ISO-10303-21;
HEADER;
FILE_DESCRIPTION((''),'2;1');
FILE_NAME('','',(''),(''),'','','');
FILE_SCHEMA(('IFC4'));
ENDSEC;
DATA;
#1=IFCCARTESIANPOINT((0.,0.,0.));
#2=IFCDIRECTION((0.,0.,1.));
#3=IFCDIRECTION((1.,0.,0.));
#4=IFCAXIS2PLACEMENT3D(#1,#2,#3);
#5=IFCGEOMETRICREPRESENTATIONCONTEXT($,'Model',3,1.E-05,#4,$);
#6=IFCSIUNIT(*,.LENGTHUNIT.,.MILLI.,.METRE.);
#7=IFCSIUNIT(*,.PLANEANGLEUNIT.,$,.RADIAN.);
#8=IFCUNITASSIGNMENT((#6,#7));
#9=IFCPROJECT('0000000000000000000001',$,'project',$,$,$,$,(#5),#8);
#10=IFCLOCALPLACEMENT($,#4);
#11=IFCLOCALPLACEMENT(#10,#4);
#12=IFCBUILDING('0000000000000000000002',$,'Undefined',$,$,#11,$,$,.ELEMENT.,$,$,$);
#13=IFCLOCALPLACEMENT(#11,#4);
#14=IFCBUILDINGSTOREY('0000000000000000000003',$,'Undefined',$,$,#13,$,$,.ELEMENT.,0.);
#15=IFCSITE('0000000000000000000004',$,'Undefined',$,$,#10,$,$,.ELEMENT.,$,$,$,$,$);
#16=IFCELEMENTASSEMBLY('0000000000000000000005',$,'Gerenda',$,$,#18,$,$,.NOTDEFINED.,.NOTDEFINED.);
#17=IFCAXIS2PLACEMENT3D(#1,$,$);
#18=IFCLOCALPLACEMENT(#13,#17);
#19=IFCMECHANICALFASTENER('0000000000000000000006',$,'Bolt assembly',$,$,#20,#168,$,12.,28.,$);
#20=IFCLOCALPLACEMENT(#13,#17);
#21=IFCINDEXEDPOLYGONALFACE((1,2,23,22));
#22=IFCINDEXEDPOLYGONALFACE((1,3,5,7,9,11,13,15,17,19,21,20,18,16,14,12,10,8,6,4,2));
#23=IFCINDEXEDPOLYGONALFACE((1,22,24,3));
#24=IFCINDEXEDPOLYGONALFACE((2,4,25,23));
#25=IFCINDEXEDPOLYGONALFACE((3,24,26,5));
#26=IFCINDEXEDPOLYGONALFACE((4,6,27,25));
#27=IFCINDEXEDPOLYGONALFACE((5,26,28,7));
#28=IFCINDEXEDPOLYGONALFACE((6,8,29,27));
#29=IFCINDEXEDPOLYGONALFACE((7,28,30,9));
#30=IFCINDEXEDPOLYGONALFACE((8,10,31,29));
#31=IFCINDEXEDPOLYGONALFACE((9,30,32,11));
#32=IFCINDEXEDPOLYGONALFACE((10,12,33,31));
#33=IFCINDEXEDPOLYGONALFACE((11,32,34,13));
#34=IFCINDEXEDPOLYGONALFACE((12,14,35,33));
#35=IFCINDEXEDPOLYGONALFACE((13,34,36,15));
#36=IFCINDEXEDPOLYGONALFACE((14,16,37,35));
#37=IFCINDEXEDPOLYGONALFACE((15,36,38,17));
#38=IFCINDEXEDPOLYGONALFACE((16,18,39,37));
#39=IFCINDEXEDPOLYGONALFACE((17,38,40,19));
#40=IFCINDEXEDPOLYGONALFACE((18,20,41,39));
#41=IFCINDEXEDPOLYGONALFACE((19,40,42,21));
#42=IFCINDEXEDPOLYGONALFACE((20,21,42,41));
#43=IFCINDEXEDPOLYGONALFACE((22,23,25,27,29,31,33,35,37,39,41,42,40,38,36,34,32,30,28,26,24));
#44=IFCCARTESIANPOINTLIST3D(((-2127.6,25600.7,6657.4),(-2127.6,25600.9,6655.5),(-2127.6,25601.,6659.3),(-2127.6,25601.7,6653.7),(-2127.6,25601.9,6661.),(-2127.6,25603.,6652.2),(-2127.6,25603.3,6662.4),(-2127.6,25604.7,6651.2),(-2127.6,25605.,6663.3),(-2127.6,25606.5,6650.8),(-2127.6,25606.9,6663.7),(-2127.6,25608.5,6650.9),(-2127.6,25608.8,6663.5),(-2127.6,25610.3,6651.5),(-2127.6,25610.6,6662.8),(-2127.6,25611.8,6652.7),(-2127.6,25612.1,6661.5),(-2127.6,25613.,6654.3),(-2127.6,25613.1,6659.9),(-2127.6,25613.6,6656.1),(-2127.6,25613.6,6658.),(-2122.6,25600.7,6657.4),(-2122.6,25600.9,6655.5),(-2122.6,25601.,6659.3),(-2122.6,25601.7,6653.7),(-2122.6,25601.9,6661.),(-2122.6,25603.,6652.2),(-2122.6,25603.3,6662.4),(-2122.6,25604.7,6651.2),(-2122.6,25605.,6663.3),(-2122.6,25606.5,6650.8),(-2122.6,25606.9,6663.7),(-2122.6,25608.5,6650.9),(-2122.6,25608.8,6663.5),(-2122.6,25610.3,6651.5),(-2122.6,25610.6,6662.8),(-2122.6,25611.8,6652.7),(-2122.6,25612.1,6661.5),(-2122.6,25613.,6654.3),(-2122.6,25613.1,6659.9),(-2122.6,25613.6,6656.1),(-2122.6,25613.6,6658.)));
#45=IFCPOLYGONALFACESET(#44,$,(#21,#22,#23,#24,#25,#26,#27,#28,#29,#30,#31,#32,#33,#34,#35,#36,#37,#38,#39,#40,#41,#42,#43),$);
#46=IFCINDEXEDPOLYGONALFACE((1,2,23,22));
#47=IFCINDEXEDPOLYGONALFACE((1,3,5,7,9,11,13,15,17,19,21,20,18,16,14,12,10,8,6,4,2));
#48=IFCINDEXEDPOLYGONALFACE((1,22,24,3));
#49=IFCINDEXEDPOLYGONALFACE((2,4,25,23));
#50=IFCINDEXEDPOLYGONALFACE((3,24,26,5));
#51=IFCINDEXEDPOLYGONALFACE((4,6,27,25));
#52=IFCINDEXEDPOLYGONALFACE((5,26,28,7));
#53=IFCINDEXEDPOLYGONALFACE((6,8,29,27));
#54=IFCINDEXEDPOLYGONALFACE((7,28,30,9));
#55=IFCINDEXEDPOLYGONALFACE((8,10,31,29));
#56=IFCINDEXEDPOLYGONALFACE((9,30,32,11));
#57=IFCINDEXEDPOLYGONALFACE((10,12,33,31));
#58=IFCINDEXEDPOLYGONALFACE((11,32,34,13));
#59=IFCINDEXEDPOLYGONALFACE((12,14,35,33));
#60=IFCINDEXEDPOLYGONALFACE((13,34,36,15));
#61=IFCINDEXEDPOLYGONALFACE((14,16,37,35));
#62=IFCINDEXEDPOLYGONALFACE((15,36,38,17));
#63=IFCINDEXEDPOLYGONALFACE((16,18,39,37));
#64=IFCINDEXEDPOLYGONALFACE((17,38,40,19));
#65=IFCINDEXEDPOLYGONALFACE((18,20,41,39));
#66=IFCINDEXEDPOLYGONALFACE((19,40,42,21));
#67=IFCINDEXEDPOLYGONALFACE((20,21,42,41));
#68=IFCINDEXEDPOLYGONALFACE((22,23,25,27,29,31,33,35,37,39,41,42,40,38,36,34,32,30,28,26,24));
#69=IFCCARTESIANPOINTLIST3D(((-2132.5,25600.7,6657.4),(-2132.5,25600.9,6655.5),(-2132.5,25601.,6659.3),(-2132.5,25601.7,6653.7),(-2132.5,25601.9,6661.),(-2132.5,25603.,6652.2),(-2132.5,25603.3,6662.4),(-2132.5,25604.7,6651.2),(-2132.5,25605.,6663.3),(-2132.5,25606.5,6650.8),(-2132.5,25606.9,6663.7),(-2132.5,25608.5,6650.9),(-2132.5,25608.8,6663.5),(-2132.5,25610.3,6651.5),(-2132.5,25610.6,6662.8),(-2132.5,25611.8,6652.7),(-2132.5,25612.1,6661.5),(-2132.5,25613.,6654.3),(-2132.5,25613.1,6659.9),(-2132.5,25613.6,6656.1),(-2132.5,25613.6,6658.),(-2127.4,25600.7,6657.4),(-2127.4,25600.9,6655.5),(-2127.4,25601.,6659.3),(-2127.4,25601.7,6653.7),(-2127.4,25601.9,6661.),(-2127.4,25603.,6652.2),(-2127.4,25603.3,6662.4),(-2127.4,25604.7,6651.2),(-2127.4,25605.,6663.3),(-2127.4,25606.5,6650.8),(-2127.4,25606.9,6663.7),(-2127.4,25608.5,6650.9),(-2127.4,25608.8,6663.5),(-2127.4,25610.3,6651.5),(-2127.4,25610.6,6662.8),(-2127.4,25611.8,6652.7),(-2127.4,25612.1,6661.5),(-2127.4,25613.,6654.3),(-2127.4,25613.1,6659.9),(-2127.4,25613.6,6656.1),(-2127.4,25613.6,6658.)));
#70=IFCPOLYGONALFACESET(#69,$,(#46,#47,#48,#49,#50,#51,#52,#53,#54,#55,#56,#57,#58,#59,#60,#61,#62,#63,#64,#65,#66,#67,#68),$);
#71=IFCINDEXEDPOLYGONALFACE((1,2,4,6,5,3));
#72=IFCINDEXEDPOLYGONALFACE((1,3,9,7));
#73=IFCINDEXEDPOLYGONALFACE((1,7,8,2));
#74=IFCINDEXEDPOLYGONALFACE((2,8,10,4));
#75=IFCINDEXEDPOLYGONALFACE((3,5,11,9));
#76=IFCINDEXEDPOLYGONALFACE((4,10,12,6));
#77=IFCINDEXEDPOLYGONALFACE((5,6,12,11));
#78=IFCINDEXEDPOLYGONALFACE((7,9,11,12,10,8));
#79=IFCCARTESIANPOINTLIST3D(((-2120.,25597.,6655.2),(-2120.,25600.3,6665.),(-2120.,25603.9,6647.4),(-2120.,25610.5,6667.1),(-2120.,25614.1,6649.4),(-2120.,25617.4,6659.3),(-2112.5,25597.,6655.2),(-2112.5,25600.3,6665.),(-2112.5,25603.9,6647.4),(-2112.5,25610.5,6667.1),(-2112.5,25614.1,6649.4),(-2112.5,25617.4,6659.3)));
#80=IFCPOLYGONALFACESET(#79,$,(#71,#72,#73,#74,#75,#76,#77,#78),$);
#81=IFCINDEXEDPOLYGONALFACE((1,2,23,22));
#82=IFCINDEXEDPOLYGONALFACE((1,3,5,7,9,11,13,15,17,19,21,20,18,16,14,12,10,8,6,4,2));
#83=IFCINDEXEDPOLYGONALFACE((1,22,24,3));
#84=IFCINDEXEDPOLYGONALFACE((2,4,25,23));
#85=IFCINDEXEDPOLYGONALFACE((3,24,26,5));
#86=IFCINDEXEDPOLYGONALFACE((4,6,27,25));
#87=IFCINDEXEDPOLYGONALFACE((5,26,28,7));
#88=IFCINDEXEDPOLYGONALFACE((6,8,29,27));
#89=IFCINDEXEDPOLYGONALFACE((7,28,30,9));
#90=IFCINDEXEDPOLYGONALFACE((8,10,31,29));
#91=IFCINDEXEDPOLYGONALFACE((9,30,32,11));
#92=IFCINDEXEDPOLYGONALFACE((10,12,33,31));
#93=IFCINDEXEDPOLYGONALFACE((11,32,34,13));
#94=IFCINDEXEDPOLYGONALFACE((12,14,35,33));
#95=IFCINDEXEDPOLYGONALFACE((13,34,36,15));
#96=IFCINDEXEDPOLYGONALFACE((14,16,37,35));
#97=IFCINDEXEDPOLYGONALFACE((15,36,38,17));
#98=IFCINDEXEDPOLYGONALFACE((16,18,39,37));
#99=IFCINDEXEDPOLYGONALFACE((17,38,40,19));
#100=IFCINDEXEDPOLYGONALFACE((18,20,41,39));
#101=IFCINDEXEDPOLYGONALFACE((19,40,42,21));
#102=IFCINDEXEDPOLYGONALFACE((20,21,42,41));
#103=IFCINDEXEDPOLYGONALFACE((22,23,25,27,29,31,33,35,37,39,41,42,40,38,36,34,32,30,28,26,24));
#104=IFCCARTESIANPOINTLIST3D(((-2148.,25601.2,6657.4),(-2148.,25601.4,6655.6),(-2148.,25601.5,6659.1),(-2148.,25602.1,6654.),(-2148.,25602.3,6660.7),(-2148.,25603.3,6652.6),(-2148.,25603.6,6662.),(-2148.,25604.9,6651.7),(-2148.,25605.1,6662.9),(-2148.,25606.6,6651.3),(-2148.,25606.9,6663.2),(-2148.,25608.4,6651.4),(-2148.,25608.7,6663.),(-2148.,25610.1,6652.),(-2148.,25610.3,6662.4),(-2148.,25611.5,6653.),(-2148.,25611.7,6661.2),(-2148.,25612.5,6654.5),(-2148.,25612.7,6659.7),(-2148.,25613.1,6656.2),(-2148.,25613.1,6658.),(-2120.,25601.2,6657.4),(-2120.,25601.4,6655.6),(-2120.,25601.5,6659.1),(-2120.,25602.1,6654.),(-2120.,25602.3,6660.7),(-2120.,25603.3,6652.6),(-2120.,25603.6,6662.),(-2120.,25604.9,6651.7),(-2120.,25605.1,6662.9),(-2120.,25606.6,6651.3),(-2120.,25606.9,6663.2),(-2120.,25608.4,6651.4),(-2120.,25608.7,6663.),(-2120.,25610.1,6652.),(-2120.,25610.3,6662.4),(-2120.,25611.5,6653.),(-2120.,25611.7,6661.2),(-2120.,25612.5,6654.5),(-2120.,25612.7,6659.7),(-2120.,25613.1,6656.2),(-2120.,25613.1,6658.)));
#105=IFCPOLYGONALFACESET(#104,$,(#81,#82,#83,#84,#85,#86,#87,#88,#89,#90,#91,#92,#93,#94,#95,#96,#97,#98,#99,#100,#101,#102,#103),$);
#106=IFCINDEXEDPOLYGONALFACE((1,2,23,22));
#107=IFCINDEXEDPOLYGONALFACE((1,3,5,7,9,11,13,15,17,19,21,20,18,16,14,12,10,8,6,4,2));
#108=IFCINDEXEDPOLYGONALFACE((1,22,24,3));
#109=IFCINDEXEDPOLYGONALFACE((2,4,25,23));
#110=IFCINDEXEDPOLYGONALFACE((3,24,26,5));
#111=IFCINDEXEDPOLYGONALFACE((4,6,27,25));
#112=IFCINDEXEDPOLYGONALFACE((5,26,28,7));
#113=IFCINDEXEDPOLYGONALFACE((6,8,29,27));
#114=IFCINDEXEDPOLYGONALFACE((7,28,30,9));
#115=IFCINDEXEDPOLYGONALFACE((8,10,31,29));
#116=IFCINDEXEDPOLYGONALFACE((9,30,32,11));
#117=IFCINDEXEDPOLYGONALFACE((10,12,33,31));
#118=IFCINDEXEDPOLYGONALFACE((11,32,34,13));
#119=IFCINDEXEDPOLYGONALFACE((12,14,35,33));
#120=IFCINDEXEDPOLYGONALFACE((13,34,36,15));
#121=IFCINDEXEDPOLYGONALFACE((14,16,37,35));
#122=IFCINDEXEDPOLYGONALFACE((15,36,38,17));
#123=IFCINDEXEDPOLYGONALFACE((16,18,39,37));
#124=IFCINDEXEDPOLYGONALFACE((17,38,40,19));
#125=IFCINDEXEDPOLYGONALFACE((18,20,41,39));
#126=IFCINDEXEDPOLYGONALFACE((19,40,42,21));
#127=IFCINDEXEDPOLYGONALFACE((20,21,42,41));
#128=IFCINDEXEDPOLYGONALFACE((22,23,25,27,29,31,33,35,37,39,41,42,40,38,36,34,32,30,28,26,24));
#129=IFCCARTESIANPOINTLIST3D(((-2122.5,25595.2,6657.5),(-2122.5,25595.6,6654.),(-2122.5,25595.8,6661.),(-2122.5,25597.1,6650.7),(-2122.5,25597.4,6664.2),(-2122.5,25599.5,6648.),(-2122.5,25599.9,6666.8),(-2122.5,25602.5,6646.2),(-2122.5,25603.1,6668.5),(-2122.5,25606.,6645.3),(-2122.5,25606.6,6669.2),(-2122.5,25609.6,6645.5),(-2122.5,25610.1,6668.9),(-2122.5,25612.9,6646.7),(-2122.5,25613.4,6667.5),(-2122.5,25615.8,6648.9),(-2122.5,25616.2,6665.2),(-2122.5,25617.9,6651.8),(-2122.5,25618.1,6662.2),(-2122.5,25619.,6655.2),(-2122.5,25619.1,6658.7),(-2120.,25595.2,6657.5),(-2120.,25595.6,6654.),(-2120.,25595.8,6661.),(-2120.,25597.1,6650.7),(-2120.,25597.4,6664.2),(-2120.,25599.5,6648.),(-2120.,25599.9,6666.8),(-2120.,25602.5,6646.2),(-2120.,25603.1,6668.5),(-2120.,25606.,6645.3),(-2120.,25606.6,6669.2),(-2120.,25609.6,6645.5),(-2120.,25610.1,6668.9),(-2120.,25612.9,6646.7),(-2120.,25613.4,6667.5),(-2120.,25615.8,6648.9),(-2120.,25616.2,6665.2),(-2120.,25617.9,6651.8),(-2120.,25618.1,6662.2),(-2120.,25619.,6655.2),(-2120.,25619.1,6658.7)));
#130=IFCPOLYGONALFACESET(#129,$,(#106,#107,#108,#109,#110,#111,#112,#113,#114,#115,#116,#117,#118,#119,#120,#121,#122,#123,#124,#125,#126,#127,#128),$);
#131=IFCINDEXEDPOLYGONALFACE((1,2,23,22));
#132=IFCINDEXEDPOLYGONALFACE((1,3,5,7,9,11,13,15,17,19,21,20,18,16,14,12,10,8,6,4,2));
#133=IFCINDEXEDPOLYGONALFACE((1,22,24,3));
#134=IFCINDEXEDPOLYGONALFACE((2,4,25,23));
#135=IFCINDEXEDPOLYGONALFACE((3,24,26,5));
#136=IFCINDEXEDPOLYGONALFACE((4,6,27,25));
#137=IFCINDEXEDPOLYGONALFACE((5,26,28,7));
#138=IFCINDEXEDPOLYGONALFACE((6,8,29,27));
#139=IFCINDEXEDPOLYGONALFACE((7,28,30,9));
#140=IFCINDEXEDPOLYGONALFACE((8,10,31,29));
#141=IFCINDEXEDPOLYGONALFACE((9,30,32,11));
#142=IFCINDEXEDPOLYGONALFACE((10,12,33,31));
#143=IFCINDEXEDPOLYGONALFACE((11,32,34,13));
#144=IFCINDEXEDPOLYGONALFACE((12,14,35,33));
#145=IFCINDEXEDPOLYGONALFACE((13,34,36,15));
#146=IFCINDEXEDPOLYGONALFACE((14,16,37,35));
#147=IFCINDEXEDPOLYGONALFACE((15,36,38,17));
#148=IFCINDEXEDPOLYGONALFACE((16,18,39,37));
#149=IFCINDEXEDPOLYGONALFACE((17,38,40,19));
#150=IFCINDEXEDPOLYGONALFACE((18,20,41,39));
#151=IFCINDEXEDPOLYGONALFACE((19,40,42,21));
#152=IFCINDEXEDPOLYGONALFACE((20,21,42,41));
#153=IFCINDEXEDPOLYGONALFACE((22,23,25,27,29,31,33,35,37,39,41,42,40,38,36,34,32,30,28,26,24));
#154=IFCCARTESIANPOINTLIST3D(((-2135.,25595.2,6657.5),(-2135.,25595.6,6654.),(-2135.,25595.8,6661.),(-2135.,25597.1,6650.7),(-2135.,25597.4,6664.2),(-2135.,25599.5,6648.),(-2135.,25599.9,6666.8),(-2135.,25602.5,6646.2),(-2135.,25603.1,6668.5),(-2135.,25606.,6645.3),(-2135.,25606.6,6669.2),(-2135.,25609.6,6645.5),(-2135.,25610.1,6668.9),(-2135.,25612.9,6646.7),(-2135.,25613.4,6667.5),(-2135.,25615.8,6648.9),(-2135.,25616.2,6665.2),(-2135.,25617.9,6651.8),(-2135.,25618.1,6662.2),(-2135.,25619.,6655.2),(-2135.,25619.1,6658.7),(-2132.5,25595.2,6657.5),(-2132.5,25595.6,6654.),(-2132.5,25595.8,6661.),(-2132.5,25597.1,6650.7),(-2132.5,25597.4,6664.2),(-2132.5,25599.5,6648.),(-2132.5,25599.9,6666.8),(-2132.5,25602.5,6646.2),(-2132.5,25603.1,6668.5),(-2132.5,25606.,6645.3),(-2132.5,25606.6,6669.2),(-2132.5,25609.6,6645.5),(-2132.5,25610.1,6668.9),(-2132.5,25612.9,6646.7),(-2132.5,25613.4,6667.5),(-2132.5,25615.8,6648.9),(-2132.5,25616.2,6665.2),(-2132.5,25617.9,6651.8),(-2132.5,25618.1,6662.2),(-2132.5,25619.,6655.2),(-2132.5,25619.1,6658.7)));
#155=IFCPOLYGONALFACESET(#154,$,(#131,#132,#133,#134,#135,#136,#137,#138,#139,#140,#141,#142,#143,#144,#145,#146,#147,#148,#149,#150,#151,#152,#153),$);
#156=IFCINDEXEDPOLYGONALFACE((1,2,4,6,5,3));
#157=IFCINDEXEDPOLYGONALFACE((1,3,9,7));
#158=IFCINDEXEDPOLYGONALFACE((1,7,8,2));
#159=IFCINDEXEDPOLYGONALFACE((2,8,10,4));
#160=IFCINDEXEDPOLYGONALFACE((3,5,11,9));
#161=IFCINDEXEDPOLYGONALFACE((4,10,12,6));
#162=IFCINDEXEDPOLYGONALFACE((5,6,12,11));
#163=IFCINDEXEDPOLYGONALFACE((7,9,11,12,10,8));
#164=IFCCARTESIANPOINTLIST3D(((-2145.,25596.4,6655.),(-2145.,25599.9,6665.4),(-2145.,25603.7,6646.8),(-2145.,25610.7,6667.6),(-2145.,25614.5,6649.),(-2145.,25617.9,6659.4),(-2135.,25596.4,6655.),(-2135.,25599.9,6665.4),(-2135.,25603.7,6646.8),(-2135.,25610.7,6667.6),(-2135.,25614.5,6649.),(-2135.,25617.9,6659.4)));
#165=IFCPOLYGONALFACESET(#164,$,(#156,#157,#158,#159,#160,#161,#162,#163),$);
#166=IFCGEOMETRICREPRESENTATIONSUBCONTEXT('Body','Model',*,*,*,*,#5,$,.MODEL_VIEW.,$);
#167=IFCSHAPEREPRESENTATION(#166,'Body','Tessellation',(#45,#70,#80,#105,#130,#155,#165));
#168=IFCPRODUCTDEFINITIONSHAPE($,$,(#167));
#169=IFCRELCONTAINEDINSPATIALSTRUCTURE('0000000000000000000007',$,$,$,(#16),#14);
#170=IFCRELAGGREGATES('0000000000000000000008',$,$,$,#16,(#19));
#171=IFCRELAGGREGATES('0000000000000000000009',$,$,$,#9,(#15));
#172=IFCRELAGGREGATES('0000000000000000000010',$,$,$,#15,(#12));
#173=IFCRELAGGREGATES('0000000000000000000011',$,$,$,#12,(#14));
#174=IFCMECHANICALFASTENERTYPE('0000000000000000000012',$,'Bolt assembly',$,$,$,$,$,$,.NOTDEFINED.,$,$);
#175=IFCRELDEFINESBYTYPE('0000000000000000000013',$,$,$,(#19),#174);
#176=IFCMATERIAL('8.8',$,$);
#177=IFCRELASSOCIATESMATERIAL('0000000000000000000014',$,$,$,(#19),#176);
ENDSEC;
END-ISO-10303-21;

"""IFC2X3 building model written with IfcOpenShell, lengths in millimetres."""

from ifc_helpers import new_model, si_unit, frame, origin_with_axes, origin_2d_with_axis, place, context, subcontext, project, spatial, polyline, circle, outline, extrude, source, transform, mapped, material, type_object, element, aggregate, save


model = new_model("IFC2X3")

# Units and contexts
model_context = context("Model", 3, precision=1e-05, world=origin_with_axes())
body_context = subcontext(model_context, "Body", "Model", "MODEL_VIEW")
ifc_project = project(units=[si_unit("LENGTHUNIT", "METRE", prefix="MILLI"), si_unit("PLANEANGLEUNIT", "RADIAN")], contexts=[model_context])

# Site, building, storey
site_placement = place(None, origin_with_axes())
site = spatial("IfcSite", under=ifc_project, at=site_placement, Name="Undefined", CompositionType="ELEMENT")
building_placement = place(site_placement, origin_with_axes())
building = spatial("IfcBuilding", under=site, at=building_placement, Name="Undefined", CompositionType="ELEMENT")
storey_placement = place(building_placement, origin_with_axes())
storey = spatial("IfcBuildingStorey", under=building, at=storey_placement, Name="Undefined", CompositionType="ELEMENT", Elevation=0.0)

# Element assembly
assembly_1_placement = place(storey_placement, origin_with_axes())
assembly_1 = element("IfcElementAssembly", 1, at=assembly_1_placement, inside=storey, Name="Gerenda", AssemblyPlace="NOTDEFINED", PredefinedType="NOTDEFINED")

# Mechanical fastener
ifc_material_1 = material(Name="8.8")
mechanical_fastener_type = type_object("IfcMechanicalFastenerType", Name="Bolt assembly")
shared_shape_1 = source(origin_with_axes(), body_context, "Body", "SweptSolid", [
    extrude(circle(Radius=6.5, at=origin_2d_with_axis()), frame((0.0, -7.4, 0.0), z_axis=(0.0, 1.0, 0.0), x_axis=(1.0, 0.0, 0.0)), (0.0, 0.0, 1.0), 5.0),
    extrude(circle(Radius=6.5, at=origin_2d_with_axis()), frame((0.0, -2.6, 0.0), z_axis=(0.0, 1.0, 0.0), x_axis=(1.0, 0.0, 0.0)), (0.0, 0.0, 1.0), 5.1),
    extrude(outline(polyline([(9.0, -5.2), (9.0, 5.2), (0.0, 10.4), (-9.0, 5.2), (-9.0, -5.2), (0.0, -10.4), (9.0, -5.2)])), frame((0.0, -17.5, 0.0), z_axis=(0.0, 1.0, 0.0), x_axis=(1.0, 0.0, 0.0)), (0.0, 0.0, 1.0), 7.5),
    extrude(circle(Radius=6.0, at=origin_2d_with_axis()), frame((0.0, -10.0, 0.0), z_axis=(0.0, 1.0, 0.0), x_axis=(1.0, 0.0, 0.0)), (0.0, 0.0, 1.0), 28.0),
    extrude(circle(Radius=12.0, at=origin_2d_with_axis()), frame((0.0, -10.0, 0.0), z_axis=(0.0, 1.0, 0.0), x_axis=(1.0, 0.0, 0.0)), (0.0, 0.0, 1.0), 2.5),
    extrude(circle(Radius=12.0, at=origin_2d_with_axis()), frame((0.0, 2.5, 0.0), z_axis=(0.0, 1.0, 0.0), x_axis=(1.0, 0.0, 0.0)), (0.0, 0.0, 1.0), 2.5),
    extrude(outline(polyline([(9.5, -5.5), (9.5, 5.5), (0.0, 11.0), (-9.5, 5.5), (-9.5, -5.5), (0.0, -11.0), (9.5, -5.5)])), frame((0.0, 5.0, 0.0), z_axis=(0.0, 1.0, 0.0), x_axis=(1.0, 0.0, 0.0)), (0.0, 0.0, 1.0), 10.0),
])
mechanical_fastener_1_placement = place(assembly_1_placement, frame((-2130.0, 25607.2, 6657.2), z_axis=(0.0, -0.662403, 0.749147), x_axis=(0.000003, 0.749147, 0.662403)))
mechanical_fastener_1 = element("IfcMechanicalFastener", 2, at=mechanical_fastener_1_placement, type_object=mechanical_fastener_type, material=ifc_material_1, Name="Bolt assembly", NominalDiameter=12.0, NominalLength=28.0, context=body_context, shape_type="MappedRepresentation", body=[
    mapped(shared_shape_1, transform((0.0, 0.0, 0.0))),
])
aggregate(assembly_1, [mechanical_fastener_1])

save(model, "model.ifc")
